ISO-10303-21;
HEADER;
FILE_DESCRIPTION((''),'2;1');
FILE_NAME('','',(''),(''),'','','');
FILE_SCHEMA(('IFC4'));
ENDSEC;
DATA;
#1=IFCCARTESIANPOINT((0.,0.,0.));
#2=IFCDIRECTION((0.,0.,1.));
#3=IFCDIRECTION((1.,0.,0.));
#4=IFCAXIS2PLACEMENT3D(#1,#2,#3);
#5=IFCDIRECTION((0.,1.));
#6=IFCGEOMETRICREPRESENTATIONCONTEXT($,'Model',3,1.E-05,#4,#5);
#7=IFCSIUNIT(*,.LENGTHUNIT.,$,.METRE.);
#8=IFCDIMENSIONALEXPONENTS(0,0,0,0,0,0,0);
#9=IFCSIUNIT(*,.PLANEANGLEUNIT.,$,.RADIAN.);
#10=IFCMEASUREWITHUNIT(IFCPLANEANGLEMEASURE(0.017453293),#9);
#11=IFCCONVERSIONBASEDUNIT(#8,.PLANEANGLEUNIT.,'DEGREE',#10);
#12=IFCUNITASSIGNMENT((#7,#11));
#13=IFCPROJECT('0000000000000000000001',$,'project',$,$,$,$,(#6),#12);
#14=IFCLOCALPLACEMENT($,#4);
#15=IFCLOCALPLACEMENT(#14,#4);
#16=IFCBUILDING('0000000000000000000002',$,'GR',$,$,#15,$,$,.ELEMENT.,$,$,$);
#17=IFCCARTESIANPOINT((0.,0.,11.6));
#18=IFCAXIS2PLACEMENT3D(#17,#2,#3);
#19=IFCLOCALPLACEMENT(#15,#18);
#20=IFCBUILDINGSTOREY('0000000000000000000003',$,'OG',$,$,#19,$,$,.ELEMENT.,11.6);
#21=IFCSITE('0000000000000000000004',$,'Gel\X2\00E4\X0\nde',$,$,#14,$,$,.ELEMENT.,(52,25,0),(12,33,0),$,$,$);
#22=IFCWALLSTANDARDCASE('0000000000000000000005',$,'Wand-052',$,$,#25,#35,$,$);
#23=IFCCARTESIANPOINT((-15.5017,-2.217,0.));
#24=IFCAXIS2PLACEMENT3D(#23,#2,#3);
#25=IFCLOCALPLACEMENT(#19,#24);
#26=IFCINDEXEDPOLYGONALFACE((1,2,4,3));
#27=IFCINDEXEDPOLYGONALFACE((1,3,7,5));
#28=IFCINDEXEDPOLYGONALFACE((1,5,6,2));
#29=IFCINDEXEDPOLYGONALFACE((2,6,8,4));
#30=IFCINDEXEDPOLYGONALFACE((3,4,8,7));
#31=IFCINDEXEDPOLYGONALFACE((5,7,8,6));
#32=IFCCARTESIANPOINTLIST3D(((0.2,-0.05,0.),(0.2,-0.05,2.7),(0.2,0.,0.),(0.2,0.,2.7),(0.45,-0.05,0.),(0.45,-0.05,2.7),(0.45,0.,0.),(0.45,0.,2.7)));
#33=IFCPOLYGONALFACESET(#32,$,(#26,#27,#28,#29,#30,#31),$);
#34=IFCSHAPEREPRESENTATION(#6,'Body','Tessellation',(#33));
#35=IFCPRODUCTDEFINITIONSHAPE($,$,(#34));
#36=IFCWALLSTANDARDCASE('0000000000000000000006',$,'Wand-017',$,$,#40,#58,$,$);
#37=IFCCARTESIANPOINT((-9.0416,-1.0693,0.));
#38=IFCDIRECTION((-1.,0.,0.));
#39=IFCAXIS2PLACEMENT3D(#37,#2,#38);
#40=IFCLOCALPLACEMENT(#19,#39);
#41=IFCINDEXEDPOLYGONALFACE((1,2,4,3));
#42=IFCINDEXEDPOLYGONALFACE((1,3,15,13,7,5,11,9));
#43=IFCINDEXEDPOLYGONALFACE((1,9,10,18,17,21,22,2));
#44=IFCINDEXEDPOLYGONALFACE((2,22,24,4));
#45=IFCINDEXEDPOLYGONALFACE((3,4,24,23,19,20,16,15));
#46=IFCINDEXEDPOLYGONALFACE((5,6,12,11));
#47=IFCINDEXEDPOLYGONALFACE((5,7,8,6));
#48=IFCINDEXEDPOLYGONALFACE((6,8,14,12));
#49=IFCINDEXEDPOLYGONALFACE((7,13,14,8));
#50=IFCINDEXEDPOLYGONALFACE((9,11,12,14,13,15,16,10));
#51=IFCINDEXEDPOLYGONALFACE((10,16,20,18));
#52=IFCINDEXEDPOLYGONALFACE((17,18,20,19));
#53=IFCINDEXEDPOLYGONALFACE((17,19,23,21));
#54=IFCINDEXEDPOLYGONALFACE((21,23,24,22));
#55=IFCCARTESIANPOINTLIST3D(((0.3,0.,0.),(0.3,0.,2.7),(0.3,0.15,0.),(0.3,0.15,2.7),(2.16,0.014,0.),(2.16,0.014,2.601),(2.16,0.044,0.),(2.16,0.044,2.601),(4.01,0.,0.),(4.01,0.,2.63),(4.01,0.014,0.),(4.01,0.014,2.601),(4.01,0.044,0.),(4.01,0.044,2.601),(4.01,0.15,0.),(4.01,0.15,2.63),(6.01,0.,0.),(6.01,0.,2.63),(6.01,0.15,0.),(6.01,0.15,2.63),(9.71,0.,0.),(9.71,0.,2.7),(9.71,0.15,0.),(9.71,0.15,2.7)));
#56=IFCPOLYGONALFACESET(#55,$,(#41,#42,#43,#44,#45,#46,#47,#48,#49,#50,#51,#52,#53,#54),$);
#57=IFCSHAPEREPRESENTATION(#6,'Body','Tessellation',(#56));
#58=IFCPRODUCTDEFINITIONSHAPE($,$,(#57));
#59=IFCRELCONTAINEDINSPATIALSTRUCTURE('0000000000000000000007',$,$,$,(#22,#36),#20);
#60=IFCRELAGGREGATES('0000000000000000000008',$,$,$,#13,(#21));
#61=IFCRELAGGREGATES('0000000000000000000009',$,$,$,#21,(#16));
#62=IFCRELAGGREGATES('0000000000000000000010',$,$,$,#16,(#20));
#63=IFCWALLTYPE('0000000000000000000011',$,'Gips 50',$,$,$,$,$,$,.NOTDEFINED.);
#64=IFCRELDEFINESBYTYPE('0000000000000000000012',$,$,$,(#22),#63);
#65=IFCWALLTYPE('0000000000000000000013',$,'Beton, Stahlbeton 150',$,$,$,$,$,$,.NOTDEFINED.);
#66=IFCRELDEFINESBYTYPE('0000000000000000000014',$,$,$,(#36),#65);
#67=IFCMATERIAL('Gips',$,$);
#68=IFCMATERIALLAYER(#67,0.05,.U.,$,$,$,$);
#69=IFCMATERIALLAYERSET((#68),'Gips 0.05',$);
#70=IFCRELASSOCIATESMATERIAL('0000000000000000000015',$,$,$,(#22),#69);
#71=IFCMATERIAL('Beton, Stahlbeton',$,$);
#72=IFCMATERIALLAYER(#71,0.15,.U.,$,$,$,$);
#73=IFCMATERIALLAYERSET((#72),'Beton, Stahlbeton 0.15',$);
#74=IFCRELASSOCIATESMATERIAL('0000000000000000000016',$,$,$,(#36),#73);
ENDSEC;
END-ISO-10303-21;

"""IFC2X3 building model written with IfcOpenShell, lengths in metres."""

from ifc_helpers import new_model, entity, si_unit, converted_unit, direction, frame, origin_with_axes, origin_2d_with_axis, place, context, project, spatial, polyline, rectangle, outline, extrude, material, layer, layer_set, layer_usage, type_object, element, save


model = new_model("IFC2X3")

# Units and contexts
model_context = context("Model", 3, precision=1e-05, world=origin_with_axes(), true_north=direction((0.0, 1.0)))
ifc_project = project(units=[si_unit("LENGTHUNIT", "METRE"), converted_unit("PLANEANGLEUNIT", "DEGREE", entity("IfcPlaneAngleMeasure", 0.017453293), si_unit("PLANEANGLEUNIT", "RADIAN"), dimensions=[0, 0, 0, 0, 0, 0, 0])], contexts=[model_context])

# Site, building, storey
site_placement = place(None, origin_with_axes())
site = spatial("IfcSite", under=ifc_project, at=site_placement, Name="Gelände", CompositionType="ELEMENT", RefLatitude=(52, 25, 0), RefLongitude=(12, 33, 0))
building_placement = place(site_placement, origin_with_axes())
building = spatial("IfcBuilding", under=site, at=building_placement, Name="GR", CompositionType="ELEMENT")
storey_placement = place(building_placement, frame((0.0, 0.0, 11.6), z_axis=(0.0, 0.0, 1.0), x_axis=(1.0, 0.0, 0.0)))
storey = spatial("IfcBuildingStorey", under=building, at=storey_placement, Name="OG", CompositionType="ELEMENT", Elevation=11.6)

# Shared definitions
ifc_material_1 = material(Name="Beton, Stahlbeton")

# Wall
ifc_material_2 = material(Name="Gips")
ifc_layer_1 = layer(ifc_material_2, 0.05, ventilated="UNKNOWN")
ifc_layer_set_1 = layer_set([ifc_layer_1], Name="Gips 0.05")
wall_type_1 = type_object("IfcWallType", Name="Gips 50", PredefinedType="NOTDEFINED")
ifc_layer_usage_1 = layer_usage(ifc_layer_set_1, "AXIS2", "NEGATIVE", 0.0)
wall_1_placement = place(storey_placement, frame((-15.5017, -2.217, 0.0), z_axis=(0.0, 0.0, 1.0), x_axis=(1.0, 0.0, 0.0)))
element("IfcWallStandardCase", 1, at=wall_1_placement, inside=storey, type_object=wall_type_1, material=ifc_layer_usage_1, Name="Wand-052", context=model_context, shape_type="SweptSolid", body=[
    extrude(outline(polyline([(0.2, -0.05), (0.45, -0.05), (0.45, 0.0), (0.2, 0.0), (0.2, -0.05)])), origin_with_axes(), (0.0, 0.0, 1.0), 2.7),
])

# Wall, opening
ifc_layer_2 = layer(ifc_material_1, 0.15, ventilated="UNKNOWN")
ifc_layer_set_2 = layer_set([ifc_layer_2], Name="Beton, Stahlbeton 0.15")
ifc_layer_usage_2 = layer_usage(ifc_layer_set_2, "AXIS2", "POSITIVE", 0.0)
wall_type_2 = type_object("IfcWallType", Name="Beton, Stahlbeton 150", PredefinedType="NOTDEFINED")
wall_2_placement = place(storey_placement, frame((-9.0416, -1.0693, 0.0), z_axis=(0.0, 0.0, 1.0), x_axis=(-1.0, 0.0, 0.0)))
wall_2 = element("IfcWallStandardCase", 2, at=wall_2_placement, inside=storey, type_object=wall_type_2, material=ifc_layer_usage_2, Name="Wand-017", context=model_context, shape_type="SweptSolid", body=[
    extrude(outline(polyline([(0.3, 0.0), (9.71, 0.0), (9.71, 0.15), (0.3, 0.15), (0.3, 0.0)])), origin_with_axes(), (0.0, 0.0, 1.0), 2.7),
])
opening_1_placement = place(wall_2_placement, frame((5.01, 0.0, 0.0), z_axis=(0.0, 0.0, 1.0), x_axis=(1.0, 0.0, 0.0)))
element("IfcOpeningElement", 3, at=opening_1_placement, cuts=wall_2, context=model_context, shape_type="SweptSolid", body=[
    extrude(rectangle(XDim=2.0, YDim=2.63, at=origin_2d_with_axis()), frame((0.0, -0.001, 1.315), z_axis=(0.0, 1.0, 0.0), x_axis=(1.0, 0.0, 0.0)), (0.0, 0.0, 1.0), 0.452),
    extrude(outline(polyline([(-1.0, 0.044), (-2.85, 0.044), (-2.85, 0.014), (-1.0, 0.014), (-1.0, 0.044)])), frame((0.0, 0.0, -0.001), z_axis=(0.0, 0.0, 1.0), x_axis=(1.0, 0.0, 0.0)), (0.0, 0.0, 1.0), 2.602),
])

save(model, "model.ifc")
